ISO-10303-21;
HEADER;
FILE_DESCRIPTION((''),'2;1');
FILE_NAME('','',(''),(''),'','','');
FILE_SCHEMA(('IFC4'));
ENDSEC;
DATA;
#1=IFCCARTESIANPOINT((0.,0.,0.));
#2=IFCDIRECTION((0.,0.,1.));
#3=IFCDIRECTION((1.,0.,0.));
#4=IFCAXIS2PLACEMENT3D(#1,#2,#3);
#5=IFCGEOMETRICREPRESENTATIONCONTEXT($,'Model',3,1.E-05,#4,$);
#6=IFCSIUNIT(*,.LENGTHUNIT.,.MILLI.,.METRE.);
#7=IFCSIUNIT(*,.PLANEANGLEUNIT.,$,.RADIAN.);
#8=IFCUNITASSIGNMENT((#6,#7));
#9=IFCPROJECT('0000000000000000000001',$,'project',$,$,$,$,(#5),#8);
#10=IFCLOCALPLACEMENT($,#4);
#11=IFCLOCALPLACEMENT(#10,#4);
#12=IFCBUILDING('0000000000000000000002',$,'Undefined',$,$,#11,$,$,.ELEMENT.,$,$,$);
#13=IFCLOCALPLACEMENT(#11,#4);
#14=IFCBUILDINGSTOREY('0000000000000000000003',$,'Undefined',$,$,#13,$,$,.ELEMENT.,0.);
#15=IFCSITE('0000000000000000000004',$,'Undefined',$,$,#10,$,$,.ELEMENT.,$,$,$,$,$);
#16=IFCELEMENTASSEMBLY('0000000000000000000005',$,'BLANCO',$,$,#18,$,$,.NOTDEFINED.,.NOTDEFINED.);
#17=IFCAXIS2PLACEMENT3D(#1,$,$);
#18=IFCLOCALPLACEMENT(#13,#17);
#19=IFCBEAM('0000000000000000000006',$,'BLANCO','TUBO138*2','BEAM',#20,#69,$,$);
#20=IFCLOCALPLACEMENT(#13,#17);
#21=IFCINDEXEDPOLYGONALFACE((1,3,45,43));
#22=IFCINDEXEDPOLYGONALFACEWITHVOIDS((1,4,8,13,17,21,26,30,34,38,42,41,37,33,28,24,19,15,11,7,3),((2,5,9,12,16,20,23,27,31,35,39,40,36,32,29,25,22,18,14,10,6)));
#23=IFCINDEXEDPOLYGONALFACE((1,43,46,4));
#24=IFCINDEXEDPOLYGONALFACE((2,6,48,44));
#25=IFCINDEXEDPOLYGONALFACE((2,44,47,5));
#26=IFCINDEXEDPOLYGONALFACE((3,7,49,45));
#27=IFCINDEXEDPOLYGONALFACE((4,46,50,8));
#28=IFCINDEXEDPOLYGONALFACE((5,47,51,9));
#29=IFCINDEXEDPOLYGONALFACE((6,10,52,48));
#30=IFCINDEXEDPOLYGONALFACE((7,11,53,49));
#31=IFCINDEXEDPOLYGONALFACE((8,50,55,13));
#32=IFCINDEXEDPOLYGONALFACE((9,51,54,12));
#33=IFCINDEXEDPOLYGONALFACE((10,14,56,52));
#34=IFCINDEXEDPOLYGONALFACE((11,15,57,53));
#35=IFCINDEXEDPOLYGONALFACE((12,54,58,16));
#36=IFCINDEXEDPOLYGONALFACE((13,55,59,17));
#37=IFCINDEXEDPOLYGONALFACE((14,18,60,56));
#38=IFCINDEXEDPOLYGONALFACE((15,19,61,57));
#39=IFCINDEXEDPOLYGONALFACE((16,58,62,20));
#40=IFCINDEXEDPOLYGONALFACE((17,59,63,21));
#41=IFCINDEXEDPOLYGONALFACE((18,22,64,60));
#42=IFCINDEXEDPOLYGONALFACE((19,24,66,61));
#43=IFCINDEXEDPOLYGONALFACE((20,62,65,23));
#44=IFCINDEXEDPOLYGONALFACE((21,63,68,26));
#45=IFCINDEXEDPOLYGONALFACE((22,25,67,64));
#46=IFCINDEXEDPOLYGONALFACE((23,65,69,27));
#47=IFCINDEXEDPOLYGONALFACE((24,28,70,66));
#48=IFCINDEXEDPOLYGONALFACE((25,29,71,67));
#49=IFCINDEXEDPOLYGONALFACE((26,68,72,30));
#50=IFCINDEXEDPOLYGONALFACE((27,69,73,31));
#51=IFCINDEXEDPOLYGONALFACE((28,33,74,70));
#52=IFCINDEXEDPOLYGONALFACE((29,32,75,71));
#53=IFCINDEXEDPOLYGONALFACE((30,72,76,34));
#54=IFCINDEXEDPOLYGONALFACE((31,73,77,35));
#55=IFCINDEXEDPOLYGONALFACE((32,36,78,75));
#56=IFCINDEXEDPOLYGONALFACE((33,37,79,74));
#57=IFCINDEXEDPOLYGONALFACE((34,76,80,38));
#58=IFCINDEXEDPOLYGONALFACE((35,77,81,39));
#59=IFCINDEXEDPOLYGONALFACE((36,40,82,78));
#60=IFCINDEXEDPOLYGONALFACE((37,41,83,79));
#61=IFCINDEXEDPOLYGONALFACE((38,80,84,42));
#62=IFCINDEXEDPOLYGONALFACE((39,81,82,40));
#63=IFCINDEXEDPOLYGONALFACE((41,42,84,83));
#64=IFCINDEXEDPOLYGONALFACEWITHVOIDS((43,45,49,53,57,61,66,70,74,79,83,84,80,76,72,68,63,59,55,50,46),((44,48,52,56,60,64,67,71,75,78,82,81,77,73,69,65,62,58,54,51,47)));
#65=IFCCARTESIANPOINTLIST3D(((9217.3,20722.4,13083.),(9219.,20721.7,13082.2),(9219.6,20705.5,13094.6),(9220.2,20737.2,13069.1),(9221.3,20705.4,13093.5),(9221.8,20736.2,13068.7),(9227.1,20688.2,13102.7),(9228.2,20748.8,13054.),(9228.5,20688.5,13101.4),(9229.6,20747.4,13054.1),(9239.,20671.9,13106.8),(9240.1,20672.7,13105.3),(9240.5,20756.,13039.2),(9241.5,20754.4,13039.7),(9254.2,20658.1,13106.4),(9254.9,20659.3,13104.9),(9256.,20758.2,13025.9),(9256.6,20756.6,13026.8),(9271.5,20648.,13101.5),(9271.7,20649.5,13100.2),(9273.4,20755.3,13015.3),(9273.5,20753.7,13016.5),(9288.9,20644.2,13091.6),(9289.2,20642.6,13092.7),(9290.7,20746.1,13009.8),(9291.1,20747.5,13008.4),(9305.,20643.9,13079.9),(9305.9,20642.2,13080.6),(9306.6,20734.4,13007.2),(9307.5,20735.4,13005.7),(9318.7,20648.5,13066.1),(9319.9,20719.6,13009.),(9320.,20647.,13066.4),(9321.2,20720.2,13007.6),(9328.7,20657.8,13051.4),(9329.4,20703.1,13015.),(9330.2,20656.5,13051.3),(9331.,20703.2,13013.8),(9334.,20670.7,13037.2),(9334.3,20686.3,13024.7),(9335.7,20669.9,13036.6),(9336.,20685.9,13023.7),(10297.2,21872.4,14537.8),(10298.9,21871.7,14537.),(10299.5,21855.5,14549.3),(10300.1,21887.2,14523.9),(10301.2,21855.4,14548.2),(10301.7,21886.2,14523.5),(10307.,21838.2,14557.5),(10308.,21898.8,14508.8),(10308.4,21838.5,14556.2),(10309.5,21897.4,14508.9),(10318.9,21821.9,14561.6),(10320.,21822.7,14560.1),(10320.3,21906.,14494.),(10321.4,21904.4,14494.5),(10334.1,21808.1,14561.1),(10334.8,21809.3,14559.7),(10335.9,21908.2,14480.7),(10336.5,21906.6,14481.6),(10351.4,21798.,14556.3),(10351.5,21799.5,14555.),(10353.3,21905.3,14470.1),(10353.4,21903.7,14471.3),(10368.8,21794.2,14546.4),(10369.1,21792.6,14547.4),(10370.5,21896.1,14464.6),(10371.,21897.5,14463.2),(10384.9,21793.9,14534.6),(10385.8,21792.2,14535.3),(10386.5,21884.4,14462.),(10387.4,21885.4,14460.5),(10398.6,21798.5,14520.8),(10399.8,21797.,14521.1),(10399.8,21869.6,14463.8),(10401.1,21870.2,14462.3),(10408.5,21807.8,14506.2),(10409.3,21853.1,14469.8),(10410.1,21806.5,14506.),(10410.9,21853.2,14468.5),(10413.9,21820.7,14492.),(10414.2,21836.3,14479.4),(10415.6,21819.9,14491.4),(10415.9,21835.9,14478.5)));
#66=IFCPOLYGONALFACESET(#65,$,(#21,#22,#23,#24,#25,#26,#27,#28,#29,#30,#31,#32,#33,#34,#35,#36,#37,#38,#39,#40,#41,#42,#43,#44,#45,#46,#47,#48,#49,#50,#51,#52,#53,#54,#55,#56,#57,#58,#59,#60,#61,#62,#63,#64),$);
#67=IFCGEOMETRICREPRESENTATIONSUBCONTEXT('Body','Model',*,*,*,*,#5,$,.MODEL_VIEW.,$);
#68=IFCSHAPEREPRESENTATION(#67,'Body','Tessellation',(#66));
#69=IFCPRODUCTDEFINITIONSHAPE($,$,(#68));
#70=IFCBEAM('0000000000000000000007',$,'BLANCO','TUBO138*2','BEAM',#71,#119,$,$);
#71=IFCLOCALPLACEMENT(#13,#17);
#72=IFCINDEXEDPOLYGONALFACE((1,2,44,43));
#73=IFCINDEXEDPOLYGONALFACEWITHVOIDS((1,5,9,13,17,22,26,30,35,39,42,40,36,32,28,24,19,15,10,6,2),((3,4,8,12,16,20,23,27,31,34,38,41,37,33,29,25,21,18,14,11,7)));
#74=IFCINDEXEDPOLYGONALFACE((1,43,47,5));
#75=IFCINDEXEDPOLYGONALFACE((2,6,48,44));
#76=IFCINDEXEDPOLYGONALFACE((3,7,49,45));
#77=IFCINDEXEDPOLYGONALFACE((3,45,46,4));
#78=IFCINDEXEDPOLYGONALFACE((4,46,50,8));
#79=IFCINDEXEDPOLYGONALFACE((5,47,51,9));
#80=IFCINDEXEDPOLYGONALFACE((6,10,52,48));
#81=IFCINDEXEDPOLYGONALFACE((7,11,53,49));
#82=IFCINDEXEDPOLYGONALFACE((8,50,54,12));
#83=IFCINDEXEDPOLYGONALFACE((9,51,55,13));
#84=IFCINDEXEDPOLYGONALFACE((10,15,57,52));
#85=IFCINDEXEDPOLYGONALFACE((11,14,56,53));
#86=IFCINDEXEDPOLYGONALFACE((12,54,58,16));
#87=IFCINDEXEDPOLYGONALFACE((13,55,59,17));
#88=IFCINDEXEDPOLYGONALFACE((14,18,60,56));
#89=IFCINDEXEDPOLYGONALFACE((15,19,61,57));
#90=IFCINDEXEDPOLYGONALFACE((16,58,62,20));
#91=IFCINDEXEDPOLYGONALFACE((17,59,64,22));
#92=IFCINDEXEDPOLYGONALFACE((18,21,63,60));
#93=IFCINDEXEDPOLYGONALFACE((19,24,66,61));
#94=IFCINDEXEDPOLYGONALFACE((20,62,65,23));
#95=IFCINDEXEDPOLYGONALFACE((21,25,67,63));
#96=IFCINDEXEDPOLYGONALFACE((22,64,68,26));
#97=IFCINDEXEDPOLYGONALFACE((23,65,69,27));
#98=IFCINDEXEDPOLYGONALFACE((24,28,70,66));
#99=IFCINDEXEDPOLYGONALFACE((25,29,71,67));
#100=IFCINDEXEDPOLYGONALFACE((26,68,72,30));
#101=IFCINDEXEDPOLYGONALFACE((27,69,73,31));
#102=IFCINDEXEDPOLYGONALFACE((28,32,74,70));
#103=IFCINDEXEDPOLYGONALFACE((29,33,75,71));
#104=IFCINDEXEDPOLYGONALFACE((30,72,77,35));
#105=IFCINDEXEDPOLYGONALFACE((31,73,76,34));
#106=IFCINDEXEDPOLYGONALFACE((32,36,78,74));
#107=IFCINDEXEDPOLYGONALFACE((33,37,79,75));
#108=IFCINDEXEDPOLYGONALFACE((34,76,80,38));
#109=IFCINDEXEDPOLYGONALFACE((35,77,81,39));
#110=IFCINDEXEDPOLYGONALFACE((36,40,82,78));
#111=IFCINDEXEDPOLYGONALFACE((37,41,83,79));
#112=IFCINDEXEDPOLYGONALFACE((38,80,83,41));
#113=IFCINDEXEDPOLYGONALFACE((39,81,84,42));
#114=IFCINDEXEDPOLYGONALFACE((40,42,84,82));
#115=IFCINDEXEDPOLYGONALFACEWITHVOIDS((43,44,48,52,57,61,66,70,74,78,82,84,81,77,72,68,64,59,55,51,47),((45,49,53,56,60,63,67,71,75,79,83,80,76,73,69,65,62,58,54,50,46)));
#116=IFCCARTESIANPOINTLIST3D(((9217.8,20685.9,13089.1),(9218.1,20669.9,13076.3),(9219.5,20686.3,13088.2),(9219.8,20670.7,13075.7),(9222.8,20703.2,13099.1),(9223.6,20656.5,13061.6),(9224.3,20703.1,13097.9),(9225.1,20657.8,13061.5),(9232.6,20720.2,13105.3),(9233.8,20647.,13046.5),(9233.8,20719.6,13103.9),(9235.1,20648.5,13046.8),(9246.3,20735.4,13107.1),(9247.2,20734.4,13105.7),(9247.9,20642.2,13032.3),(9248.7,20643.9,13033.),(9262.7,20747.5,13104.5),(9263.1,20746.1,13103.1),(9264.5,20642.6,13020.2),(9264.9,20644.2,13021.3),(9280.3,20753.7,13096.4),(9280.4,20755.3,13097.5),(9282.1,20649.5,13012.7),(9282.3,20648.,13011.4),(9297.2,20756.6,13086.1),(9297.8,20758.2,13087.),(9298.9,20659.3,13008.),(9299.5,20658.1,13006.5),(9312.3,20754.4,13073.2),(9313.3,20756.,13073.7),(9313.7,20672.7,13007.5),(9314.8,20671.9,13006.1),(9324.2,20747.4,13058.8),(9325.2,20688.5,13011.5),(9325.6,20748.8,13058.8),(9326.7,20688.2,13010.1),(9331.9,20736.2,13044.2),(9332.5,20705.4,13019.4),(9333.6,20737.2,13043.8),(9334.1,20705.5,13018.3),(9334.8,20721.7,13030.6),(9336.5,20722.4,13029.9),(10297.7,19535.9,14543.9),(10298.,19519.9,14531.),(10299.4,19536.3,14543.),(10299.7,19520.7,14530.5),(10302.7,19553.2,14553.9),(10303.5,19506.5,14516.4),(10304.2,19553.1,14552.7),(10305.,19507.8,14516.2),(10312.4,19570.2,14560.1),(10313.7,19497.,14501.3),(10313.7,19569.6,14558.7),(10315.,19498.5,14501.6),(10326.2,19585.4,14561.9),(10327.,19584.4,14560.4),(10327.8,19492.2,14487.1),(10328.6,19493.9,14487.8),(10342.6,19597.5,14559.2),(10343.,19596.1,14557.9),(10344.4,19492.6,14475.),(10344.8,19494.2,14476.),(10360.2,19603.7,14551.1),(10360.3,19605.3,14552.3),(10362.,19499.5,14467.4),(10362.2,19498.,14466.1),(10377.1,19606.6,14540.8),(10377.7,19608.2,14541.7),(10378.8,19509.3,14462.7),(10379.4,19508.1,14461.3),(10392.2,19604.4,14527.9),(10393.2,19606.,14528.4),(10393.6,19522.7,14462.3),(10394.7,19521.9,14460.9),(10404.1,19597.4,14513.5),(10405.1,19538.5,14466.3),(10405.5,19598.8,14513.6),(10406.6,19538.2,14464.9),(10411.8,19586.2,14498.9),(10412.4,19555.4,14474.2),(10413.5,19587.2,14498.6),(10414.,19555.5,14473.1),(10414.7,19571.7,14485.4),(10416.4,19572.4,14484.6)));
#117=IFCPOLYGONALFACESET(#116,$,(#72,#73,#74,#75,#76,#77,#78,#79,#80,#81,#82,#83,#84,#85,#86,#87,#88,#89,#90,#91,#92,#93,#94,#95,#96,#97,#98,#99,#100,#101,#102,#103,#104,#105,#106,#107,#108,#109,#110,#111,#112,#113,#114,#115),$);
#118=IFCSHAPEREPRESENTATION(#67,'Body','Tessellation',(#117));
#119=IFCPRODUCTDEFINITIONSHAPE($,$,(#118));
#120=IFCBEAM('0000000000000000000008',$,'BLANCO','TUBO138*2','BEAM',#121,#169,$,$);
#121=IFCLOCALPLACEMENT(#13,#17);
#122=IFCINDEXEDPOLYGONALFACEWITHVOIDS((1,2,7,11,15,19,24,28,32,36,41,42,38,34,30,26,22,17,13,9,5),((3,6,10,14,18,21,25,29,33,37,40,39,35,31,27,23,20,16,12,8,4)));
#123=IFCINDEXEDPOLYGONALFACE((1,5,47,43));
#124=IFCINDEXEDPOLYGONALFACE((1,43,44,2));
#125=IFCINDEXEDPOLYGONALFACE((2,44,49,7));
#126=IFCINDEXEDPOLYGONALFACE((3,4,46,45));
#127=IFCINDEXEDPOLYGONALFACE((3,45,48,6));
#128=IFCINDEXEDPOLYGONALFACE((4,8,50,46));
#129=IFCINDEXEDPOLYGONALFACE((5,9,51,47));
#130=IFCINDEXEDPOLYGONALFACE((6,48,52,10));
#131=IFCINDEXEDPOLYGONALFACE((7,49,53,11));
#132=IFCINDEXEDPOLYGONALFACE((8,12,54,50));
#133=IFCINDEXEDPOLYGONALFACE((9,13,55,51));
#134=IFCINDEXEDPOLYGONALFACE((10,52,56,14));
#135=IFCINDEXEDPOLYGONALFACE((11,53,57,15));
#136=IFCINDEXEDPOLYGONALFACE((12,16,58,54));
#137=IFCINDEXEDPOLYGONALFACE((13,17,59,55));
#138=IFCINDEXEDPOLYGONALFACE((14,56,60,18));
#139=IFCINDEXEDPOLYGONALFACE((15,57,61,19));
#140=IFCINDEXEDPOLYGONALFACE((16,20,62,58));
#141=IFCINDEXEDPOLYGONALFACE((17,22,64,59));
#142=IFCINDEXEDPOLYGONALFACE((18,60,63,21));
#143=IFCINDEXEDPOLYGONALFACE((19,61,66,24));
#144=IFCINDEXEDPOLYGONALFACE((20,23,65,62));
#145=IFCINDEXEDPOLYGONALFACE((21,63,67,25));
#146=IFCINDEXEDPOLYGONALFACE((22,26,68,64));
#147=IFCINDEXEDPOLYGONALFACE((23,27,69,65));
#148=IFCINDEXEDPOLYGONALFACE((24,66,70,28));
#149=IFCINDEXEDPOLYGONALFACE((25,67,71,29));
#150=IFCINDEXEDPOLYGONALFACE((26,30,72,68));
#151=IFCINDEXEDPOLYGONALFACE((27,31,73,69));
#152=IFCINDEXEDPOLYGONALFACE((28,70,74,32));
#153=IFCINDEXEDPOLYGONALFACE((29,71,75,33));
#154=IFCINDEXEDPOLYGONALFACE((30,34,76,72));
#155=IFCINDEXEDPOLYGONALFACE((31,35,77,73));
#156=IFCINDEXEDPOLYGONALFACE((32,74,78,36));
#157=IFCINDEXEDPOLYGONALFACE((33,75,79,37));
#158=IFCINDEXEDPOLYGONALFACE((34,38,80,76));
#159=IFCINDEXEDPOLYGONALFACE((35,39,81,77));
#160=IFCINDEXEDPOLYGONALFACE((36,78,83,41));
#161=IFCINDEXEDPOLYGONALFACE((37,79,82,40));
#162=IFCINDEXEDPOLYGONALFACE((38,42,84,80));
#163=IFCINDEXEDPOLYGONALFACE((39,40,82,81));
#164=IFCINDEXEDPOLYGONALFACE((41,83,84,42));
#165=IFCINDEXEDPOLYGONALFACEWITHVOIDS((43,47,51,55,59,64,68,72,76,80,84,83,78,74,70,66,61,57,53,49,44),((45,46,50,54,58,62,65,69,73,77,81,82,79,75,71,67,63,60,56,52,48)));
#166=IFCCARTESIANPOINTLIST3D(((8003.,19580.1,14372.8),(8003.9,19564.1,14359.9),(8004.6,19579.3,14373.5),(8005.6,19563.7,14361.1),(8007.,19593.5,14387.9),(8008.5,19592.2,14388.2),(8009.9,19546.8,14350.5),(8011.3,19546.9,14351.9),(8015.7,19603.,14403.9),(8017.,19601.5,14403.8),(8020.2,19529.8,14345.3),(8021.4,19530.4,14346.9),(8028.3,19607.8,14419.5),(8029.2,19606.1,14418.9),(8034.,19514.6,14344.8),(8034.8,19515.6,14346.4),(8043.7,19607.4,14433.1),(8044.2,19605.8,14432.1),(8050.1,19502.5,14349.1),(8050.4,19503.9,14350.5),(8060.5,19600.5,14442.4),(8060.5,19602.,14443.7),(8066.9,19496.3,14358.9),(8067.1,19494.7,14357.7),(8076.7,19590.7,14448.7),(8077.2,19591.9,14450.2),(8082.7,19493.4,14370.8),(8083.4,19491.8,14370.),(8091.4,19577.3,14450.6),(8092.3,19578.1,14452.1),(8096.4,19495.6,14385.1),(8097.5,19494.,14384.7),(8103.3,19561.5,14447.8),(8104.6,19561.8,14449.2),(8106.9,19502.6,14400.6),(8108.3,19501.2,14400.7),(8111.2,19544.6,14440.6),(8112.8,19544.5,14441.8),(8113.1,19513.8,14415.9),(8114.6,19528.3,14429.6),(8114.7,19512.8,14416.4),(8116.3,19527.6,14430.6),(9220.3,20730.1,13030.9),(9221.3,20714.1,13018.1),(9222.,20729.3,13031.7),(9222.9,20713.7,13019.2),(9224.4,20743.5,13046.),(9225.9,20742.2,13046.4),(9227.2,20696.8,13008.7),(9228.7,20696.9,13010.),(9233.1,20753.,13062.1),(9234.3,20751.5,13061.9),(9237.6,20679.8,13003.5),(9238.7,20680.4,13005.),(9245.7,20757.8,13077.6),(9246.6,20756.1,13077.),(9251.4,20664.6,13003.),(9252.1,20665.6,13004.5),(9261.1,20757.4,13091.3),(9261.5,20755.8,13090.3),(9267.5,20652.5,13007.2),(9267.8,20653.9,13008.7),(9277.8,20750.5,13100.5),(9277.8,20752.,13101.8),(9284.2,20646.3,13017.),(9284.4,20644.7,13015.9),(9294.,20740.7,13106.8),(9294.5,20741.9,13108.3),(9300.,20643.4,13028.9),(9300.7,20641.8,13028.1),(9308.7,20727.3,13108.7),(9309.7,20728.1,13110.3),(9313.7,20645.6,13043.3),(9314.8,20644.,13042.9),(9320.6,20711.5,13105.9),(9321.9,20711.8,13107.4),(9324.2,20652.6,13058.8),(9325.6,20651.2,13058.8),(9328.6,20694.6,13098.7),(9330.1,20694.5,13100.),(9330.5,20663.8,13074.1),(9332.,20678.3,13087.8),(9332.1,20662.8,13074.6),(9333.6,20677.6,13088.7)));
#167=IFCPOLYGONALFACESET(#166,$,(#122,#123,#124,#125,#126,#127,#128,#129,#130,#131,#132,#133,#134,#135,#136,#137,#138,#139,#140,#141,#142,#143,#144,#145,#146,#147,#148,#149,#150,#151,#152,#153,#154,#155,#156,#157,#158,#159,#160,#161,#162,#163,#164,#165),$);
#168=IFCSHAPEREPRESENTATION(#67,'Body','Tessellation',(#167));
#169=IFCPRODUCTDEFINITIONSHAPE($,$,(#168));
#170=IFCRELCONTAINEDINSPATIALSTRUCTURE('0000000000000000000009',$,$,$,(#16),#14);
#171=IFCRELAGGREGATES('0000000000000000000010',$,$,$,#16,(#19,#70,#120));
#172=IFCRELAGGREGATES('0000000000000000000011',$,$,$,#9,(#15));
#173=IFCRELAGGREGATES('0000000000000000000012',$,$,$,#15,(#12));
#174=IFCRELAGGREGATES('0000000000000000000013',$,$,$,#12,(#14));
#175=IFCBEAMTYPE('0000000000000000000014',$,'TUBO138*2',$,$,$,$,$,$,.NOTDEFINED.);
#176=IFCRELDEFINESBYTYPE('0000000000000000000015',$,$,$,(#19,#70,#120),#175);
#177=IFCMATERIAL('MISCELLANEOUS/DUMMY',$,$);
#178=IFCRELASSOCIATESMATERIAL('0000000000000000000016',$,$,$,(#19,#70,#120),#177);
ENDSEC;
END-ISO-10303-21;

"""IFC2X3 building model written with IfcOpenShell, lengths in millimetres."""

from ifc_helpers import new_model, si_unit, frame, origin_with_axes, origin_2d_with_axis, place, context, subcontext, project, spatial, hollow_circle, extrude, material, type_object, element, aggregate, save


model = new_model("IFC2X3")

# Units and contexts
model_context = context("Model", 3, precision=1e-05, world=origin_with_axes())
body_context = subcontext(model_context, "Body", "Model", "MODEL_VIEW")
ifc_project = project(units=[si_unit("LENGTHUNIT", "METRE", prefix="MILLI"), si_unit("PLANEANGLEUNIT", "RADIAN")], contexts=[model_context])

# Site, building, storey
site_placement = place(None, origin_with_axes())
site = spatial("IfcSite", under=ifc_project, at=site_placement, Name="Undefined", CompositionType="ELEMENT")
building_placement = place(site_placement, origin_with_axes())
building = spatial("IfcBuilding", under=site, at=building_placement, Name="Undefined", CompositionType="ELEMENT")
storey_placement = place(building_placement, origin_with_axes())
storey = spatial("IfcBuildingStorey", under=building, at=storey_placement, Name="Undefined", CompositionType="ELEMENT", Elevation=0.0)

# Element assembly, beams
assembly_placement = place(storey_placement, origin_with_axes())
assembly = element("IfcElementAssembly", 1, at=assembly_placement, inside=storey, Name="BLANCO", AssemblyPlace="NOTDEFINED", PredefinedType="NOTDEFINED")
ifc_material = material(Name="MISCELLANEOUS/DUMMY")
beam_type = type_object("IfcBeamType", Name="TUBO138*2", PredefinedType="NOTDEFINED")
beam_1_placement = place(assembly_placement, frame((9276.9, 20700.0, 13056.4), z_axis=(0.497966, 0.461316, -0.734314), x_axis=(0.503224, 0.535899, 0.677922)))
beam_1 = element("IfcBeam", 2, at=beam_1_placement, type_object=beam_type, material=ifc_material, Name="BLANCO", Description="TUBO138*2", ObjectType="BEAM", context=body_context, shape_type="SweptSolid", body=[
    extrude(hollow_circle(Radius=69.0, WallThickness=2.0, at=origin_2d_with_axis()), frame((2145.9, 0.0, 0.0), z_axis=(-1.0, 0.0, 0.0), x_axis=(0.0, -1.0, 0.0)), (0.0, 0.0, 1.0), 2145.9),
])
beam_2_placement = place(assembly_placement, frame((9276.9, 20700.0, 13056.4), z_axis=(0.497966, -0.461316, -0.734314), x_axis=(0.503224, -0.535899, 0.677922)))
beam_2 = element("IfcBeam", 3, at=beam_2_placement, type_object=beam_type, material=ifc_material, Name="BLANCO", Description="TUBO138*2", ObjectType="BEAM", context=body_context, shape_type="SweptSolid", body=[
    extrude(hollow_circle(Radius=69.0, WallThickness=2.0, at=origin_2d_with_axis()), frame((2145.9, 0.0, 0.0), z_axis=(-1.0, 0.0, 0.0), x_axis=(0.0, -1.0, 0.0)), (0.0, 0.0, 1.0), 2145.9),
])
beam_3_placement = place(assembly_placement, frame((9276.9, 20700.0, 13056.4), z_axis=(-0.423552, -0.461316, -0.77961), x_axis=(-0.567282, -0.535899, 0.625303)))
beam_3 = element("IfcBeam", 4, at=beam_3_placement, type_object=beam_type, material=ifc_material, Name="BLANCO", Description="TUBO138*2", ObjectType="BEAM", context=body_context, shape_type="SweptSolid", body=[
    extrude(hollow_circle(Radius=69.0, WallThickness=2.0, at=origin_2d_with_axis()), frame((2145.9, 0.0, 0.0), z_axis=(-1.0, 0.0, 0.0), x_axis=(0.0, -1.0, 0.0)), (0.0, 0.0, 1.0), 2145.9),
])
aggregate(assembly, [beam_1, beam_2, beam_3])

save(model, "model.ifc")
